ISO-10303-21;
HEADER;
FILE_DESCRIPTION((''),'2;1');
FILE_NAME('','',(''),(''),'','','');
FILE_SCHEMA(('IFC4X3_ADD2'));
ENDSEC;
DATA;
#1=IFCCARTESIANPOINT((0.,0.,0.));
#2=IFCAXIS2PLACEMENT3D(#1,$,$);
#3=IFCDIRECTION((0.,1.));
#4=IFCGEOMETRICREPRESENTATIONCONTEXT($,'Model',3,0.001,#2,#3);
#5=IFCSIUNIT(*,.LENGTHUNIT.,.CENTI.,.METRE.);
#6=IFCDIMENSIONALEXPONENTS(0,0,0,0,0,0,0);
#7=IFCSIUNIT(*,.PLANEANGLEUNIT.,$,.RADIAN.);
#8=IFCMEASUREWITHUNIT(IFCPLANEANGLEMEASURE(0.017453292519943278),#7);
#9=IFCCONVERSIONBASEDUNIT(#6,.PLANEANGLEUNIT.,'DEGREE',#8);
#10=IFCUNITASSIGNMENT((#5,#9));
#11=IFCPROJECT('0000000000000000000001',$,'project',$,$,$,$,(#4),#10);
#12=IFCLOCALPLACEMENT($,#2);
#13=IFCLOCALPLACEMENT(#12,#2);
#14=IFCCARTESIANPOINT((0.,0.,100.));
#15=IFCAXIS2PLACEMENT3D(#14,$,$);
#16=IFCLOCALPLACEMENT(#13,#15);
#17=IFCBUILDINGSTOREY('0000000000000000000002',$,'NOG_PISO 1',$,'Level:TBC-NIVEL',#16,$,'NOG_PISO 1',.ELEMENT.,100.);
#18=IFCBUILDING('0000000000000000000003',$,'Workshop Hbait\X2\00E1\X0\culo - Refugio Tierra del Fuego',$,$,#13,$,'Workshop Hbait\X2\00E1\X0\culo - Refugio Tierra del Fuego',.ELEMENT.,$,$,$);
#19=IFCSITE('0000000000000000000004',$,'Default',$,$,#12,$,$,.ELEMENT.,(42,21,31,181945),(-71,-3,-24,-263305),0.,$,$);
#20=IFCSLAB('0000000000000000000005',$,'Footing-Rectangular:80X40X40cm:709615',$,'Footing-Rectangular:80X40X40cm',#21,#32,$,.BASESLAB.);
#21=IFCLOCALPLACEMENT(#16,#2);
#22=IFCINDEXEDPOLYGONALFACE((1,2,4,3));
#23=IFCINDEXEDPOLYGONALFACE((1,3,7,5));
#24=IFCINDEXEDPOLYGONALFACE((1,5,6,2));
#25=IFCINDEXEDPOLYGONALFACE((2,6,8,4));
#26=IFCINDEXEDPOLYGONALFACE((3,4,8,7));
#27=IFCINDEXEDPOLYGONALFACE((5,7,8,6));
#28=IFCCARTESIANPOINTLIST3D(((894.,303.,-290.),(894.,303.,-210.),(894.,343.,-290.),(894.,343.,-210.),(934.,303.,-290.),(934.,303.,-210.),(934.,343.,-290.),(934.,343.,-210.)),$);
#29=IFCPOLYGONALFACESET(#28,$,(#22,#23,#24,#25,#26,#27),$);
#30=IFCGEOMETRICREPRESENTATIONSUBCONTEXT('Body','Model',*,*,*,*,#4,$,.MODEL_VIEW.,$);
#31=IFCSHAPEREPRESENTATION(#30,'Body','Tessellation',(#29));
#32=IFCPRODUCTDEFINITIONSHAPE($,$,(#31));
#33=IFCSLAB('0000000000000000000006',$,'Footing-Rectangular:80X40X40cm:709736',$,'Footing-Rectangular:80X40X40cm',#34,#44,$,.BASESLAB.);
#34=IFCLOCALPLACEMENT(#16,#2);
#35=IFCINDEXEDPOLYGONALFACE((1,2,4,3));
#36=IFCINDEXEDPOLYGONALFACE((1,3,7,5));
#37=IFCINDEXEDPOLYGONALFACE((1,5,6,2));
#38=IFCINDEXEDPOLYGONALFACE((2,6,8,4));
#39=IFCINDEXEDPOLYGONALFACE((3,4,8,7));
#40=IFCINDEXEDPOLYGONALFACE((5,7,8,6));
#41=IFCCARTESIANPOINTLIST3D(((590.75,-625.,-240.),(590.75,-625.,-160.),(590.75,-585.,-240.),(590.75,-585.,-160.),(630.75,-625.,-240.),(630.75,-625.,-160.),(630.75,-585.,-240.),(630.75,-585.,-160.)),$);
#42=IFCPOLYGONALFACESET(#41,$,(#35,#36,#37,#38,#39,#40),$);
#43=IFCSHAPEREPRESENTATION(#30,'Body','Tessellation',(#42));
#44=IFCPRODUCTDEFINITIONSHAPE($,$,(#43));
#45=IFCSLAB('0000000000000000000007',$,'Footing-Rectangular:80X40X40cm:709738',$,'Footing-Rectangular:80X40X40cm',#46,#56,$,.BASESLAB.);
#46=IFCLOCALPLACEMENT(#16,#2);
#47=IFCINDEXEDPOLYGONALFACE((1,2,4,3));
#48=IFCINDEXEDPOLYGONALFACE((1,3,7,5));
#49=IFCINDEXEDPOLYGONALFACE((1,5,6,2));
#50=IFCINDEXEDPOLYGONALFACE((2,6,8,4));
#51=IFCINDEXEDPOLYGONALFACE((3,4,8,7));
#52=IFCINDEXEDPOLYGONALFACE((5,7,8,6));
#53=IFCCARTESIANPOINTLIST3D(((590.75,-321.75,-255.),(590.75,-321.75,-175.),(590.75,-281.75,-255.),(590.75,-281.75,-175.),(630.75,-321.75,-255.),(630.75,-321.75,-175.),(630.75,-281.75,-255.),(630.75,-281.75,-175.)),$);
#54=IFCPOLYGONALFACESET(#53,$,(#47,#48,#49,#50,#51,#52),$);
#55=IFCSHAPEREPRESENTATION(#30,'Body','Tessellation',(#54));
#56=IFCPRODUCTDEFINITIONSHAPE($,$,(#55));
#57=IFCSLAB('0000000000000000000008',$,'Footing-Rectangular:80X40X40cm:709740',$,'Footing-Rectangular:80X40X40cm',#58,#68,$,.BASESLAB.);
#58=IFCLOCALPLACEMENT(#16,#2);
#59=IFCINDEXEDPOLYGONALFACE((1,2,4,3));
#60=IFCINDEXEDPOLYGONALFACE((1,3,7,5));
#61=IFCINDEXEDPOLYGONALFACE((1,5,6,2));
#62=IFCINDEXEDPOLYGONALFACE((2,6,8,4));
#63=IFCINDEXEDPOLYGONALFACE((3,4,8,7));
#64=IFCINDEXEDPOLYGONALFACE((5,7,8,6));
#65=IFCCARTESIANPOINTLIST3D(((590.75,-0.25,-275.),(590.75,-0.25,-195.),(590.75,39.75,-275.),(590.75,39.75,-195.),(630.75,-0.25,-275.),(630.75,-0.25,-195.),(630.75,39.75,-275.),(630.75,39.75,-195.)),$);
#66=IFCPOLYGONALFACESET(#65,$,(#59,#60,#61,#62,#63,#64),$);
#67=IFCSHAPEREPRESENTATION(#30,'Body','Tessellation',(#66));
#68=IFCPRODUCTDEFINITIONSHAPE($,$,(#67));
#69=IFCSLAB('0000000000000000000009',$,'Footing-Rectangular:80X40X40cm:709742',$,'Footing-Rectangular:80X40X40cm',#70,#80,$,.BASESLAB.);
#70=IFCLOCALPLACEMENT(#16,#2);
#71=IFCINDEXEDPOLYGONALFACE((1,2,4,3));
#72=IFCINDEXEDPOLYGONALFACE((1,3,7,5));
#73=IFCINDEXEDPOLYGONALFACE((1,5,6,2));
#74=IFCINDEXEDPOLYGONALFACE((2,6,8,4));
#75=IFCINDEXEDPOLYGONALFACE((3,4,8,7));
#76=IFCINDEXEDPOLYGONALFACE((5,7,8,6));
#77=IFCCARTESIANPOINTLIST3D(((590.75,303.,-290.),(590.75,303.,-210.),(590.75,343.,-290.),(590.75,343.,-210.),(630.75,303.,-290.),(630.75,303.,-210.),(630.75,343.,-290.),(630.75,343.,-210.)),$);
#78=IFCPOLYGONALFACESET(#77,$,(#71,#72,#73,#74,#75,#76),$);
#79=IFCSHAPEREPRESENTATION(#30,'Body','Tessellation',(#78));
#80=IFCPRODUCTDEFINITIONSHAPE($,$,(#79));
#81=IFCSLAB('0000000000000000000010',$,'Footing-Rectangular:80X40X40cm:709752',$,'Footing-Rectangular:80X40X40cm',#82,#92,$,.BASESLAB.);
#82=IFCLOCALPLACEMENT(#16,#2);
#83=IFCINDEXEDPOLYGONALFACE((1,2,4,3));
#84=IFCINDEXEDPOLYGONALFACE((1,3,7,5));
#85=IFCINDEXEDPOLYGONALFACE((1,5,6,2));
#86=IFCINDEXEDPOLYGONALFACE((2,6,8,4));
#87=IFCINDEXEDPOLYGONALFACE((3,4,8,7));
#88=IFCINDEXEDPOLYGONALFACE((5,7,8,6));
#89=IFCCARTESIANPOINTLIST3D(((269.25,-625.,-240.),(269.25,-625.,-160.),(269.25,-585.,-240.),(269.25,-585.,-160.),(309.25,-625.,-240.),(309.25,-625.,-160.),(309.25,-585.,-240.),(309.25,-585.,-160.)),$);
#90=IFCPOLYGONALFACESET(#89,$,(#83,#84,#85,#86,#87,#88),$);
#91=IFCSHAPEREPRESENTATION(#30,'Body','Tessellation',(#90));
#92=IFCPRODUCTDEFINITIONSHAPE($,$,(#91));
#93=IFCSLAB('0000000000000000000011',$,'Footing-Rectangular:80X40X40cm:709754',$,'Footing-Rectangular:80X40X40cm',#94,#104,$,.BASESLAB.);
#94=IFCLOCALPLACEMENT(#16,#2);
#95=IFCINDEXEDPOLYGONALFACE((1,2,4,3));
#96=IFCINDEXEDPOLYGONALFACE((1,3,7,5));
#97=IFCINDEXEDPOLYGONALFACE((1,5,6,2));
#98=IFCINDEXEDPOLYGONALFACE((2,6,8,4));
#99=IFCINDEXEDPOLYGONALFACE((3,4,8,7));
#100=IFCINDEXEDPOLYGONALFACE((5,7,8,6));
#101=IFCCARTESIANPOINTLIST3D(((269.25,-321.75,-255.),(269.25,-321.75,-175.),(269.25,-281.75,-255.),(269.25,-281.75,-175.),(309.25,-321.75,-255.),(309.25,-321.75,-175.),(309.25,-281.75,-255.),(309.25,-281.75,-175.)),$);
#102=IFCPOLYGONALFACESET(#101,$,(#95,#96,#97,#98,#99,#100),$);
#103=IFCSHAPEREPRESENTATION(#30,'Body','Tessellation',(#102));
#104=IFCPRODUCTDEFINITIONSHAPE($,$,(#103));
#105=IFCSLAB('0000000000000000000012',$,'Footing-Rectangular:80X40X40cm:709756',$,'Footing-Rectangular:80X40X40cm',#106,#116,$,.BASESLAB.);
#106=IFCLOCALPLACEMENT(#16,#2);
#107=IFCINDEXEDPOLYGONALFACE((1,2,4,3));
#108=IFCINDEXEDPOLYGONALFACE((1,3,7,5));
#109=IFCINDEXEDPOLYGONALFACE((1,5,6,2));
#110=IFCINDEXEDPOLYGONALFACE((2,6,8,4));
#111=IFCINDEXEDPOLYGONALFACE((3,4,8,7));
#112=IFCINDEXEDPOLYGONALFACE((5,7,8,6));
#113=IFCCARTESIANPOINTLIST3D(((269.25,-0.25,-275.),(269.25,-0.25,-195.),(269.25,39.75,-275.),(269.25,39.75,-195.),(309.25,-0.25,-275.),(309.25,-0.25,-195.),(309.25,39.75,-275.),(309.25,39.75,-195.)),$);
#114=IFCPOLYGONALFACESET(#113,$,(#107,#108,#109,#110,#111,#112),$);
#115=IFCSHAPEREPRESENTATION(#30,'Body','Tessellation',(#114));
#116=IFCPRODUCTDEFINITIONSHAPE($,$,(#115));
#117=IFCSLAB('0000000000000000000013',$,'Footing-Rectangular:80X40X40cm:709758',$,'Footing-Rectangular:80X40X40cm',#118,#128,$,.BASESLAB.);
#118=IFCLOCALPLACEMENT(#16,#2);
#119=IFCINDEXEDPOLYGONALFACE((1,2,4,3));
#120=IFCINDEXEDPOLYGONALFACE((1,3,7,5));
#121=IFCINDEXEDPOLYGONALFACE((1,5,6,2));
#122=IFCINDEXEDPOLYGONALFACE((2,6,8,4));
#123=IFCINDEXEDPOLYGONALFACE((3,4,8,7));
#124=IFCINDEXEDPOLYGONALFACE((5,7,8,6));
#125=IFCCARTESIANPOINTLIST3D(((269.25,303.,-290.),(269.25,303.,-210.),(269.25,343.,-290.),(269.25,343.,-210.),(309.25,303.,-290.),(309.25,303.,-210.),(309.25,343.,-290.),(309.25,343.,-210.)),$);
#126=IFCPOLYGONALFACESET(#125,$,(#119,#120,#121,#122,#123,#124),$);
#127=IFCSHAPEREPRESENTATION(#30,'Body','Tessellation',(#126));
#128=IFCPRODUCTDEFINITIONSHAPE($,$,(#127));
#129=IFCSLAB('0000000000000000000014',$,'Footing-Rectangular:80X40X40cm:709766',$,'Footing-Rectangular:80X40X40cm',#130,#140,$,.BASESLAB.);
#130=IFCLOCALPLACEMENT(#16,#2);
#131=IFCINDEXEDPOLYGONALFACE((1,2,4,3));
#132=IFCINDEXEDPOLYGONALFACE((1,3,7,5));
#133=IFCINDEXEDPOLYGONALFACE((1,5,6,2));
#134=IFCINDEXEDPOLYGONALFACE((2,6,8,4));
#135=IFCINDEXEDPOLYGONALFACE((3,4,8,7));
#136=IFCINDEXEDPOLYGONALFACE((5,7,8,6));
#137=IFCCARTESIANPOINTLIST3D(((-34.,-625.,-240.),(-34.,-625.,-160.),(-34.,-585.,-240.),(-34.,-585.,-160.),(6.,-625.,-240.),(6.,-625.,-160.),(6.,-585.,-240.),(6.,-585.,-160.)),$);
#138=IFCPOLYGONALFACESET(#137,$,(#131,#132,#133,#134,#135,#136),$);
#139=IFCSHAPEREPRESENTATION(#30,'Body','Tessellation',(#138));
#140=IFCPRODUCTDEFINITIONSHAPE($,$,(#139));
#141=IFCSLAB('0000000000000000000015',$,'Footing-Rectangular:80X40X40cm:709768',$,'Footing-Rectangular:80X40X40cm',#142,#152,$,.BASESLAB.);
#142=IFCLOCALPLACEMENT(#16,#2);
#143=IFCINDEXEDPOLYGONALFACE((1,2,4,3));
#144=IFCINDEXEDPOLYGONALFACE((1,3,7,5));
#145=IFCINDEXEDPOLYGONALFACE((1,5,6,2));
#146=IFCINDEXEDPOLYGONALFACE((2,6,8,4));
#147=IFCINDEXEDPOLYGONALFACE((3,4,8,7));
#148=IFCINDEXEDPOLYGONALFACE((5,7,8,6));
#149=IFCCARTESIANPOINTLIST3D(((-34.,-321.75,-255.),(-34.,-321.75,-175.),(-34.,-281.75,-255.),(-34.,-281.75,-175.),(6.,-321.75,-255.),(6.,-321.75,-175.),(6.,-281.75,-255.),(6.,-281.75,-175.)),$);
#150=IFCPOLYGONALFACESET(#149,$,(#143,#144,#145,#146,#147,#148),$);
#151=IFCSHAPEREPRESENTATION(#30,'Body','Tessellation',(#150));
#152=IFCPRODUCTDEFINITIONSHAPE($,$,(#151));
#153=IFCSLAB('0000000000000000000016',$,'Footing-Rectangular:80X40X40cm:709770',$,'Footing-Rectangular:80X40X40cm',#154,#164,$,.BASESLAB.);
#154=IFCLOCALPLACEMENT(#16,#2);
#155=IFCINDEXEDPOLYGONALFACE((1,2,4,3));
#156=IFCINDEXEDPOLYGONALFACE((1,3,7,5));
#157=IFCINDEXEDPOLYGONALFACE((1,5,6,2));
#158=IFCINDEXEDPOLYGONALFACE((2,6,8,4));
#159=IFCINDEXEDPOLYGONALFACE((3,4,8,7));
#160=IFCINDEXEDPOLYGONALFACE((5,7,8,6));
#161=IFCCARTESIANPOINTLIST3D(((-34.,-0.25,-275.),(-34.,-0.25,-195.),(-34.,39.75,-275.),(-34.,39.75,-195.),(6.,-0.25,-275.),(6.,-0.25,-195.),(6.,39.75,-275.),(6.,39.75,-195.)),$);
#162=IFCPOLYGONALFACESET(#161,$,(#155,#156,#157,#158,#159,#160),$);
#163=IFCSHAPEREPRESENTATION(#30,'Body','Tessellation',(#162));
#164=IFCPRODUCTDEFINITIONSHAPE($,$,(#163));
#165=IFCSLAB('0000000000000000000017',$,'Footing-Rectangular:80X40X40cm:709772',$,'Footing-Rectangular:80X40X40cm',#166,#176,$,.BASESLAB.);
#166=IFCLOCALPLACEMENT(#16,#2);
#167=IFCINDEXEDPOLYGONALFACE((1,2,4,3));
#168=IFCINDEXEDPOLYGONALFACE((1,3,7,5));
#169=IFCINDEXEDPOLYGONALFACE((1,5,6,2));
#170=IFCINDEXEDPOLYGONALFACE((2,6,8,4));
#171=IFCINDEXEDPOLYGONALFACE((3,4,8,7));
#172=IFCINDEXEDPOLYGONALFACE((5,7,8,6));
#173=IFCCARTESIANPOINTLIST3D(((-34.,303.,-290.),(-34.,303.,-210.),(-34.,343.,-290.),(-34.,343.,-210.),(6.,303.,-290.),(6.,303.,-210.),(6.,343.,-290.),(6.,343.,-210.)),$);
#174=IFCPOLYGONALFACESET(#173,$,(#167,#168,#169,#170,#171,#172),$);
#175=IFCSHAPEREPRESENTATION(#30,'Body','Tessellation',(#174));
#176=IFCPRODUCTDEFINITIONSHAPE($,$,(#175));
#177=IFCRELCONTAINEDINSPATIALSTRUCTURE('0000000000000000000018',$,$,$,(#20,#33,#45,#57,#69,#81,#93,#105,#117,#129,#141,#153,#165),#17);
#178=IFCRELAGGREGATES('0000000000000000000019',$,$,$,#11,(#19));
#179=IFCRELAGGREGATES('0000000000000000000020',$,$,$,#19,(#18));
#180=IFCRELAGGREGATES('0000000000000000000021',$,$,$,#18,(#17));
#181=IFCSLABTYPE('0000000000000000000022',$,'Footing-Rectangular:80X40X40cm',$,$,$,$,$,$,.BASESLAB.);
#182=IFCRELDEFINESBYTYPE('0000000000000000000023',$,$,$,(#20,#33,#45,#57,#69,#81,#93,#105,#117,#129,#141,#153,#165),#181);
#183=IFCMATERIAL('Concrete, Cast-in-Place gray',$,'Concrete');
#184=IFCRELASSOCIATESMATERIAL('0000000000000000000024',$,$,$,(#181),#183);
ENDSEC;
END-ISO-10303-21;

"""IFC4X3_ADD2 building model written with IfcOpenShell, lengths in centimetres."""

from ifc_helpers import new_model, entity, si_unit, converted_unit, direction, frame, frame_2d, origin, origin_2d_with_axis, place, context, subcontext, project, spatial, rectangle, extrude, material, type_object, element, save


model = new_model("IFC4X3_ADD2")

# Units and contexts
model_context = context("Model", 3, precision=0.001, world=origin(), true_north=direction((0.0, 1.0)))
body_context = subcontext(model_context, "Body", "Model", "MODEL_VIEW")
ifc_project = project(units=[si_unit("LENGTHUNIT", "METRE", prefix="CENTI"), converted_unit("PLANEANGLEUNIT", "DEGREE", entity("IfcPlaneAngleMeasure", 0.017453292519943278), si_unit("PLANEANGLEUNIT", "RADIAN"), dimensions=[0, 0, 0, 0, 0, 0, 0])], contexts=[model_context])

# Site, building, storey
site_placement = place(None, origin())
site = spatial("IfcSite", under=ifc_project, at=site_placement, Name="Default", CompositionType="ELEMENT", RefLatitude=(42, 21, 31, 181945), RefLongitude=(-71, -3, -24, -263305), RefElevation=0.0)
building_placement = place(site_placement, origin())
building = spatial("IfcBuilding", under=site, at=building_placement, Name="Workshop Hbaitáculo - Refugio Tierra del Fuego", LongName="Workshop Hbaitáculo - Refugio Tierra del Fuego", CompositionType="ELEMENT")
storey_placement = place(building_placement, frame((0.0, 0.0, 100.0)))
storey = spatial("IfcBuildingStorey", under=building, at=storey_placement, Name="NOG_PISO 1", ObjectType="Level:TBC-NIVEL", LongName="NOG_PISO 1", CompositionType="ELEMENT", Elevation=100.0)

# Slabs
ifc_material_1 = material(Name="Concrete, Cast-in-Place gray", Category="Concrete")
slab_type_1 = type_object("IfcSlabType", Name="Footing-Rectangular:80X40X40cm", PredefinedType="BASESLAB", material=ifc_material_1)
slab_1_placement = place(storey_placement, frame((0.0, 0.0, -210.0)))
element("IfcSlab", 1, at=slab_1_placement, inside=storey, type_object=slab_type_1, Name="Footing-Rectangular:80X40X40cm:709615", ObjectType="Footing-Rectangular:80X40X40cm", PredefinedType="BASESLAB", context=body_context, shape_type="SweptSolid", body=[
    extrude(rectangle(XDim=40.0, YDim=40.0, at=origin_2d_with_axis()), frame((914.0, 323.0, -80.0), z_axis=(0.0, 0.0, 1.0), x_axis=(-1.0, 0.0, 0.0)), (0.0, 0.0, 1.0), 80.0),
])
slab_2_placement = place(storey_placement, frame((0.0, 0.0, -160.0)))
element("IfcSlab", 2, at=slab_2_placement, inside=storey, type_object=slab_type_1, Name="Footing-Rectangular:80X40X40cm:709736", ObjectType="Footing-Rectangular:80X40X40cm", PredefinedType="BASESLAB", context=body_context, shape_type="SweptSolid", body=[
    extrude(rectangle(XDim=40.0, YDim=40.0, at=origin_2d_with_axis()), frame((610.75, -605.0, -80.0), z_axis=(0.0, 0.0, 1.0), x_axis=(-1.0, 0.0, 0.0)), (0.0, 0.0, 1.0), 80.0),
])
slab_3_placement = place(storey_placement, frame((0.0, 0.0, -175.0)))
element("IfcSlab", 3, at=slab_3_placement, inside=storey, type_object=slab_type_1, Name="Footing-Rectangular:80X40X40cm:709738", ObjectType="Footing-Rectangular:80X40X40cm", PredefinedType="BASESLAB", context=body_context, shape_type="SweptSolid", body=[
    extrude(rectangle(XDim=40.0, YDim=40.0, at=origin_2d_with_axis()), frame((610.75, -301.75, -80.0), z_axis=(0.0, 0.0, 1.0), x_axis=(-1.0, 0.0, 0.0)), (0.0, 0.0, 1.0), 80.0),
])
slab_4_placement = place(storey_placement, frame((0.0, 0.0, -195.0)))
element("IfcSlab", 4, at=slab_4_placement, inside=storey, type_object=slab_type_1, Name="Footing-Rectangular:80X40X40cm:709740", ObjectType="Footing-Rectangular:80X40X40cm", PredefinedType="BASESLAB", context=body_context, shape_type="SweptSolid", body=[
    extrude(rectangle(XDim=40.0, YDim=40.0, at=origin_2d_with_axis()), frame((610.75, 19.75, -80.0), z_axis=(0.0, 0.0, 1.0), x_axis=(-1.0, 0.0, 0.0)), (0.0, 0.0, 1.0), 80.0),
])
slab_5_placement = place(storey_placement, frame((0.0, 0.0, -210.0)))
element("IfcSlab", 5, at=slab_5_placement, inside=storey, type_object=slab_type_1, Name="Footing-Rectangular:80X40X40cm:709742", ObjectType="Footing-Rectangular:80X40X40cm", PredefinedType="BASESLAB", context=body_context, shape_type="SweptSolid", body=[
    extrude(rectangle(XDim=40.0, YDim=40.0, at=origin_2d_with_axis()), frame((610.75, 323.0, -80.0), z_axis=(0.0, 0.0, 1.0), x_axis=(-1.0, 0.0, 0.0)), (0.0, 0.0, 1.0), 80.0),
])
slab_6_placement = place(storey_placement, frame((0.0, 0.0, -160.0)))
element("IfcSlab", 6, at=slab_6_placement, inside=storey, type_object=slab_type_1, Name="Footing-Rectangular:80X40X40cm:709752", ObjectType="Footing-Rectangular:80X40X40cm", PredefinedType="BASESLAB", context=body_context, shape_type="SweptSolid", body=[
    extrude(rectangle(XDim=40.0, YDim=40.0, at=origin_2d_with_axis()), frame((289.25, -605.0, -80.0), z_axis=(0.0, 0.0, 1.0), x_axis=(-1.0, 0.0, 0.0)), (0.0, 0.0, 1.0), 80.0),
])
slab_7_placement = place(storey_placement, frame((0.0, 0.0, -175.0)))
element("IfcSlab", 7, at=slab_7_placement, inside=storey, type_object=slab_type_1, Name="Footing-Rectangular:80X40X40cm:709754", ObjectType="Footing-Rectangular:80X40X40cm", PredefinedType="BASESLAB", context=body_context, shape_type="SweptSolid", body=[
    extrude(rectangle(XDim=40.0, YDim=40.0, at=origin_2d_with_axis()), frame((289.25, -301.75, -80.0), z_axis=(0.0, 0.0, 1.0), x_axis=(-1.0, 0.0, 0.0)), (0.0, 0.0, 1.0), 80.0),
])
slab_8_placement = place(storey_placement, frame((0.0, 0.0, -195.0)))
element("IfcSlab", 8, at=slab_8_placement, inside=storey, type_object=slab_type_1, Name="Footing-Rectangular:80X40X40cm:709756", ObjectType="Footing-Rectangular:80X40X40cm", PredefinedType="BASESLAB", context=body_context, shape_type="SweptSolid", body=[
    extrude(rectangle(XDim=40.0, YDim=40.0, at=origin_2d_with_axis()), frame((289.25, 19.75, -80.0), z_axis=(0.0, 0.0, 1.0), x_axis=(-1.0, 0.0, 0.0)), (0.0, 0.0, 1.0), 80.0),
])
slab_9_placement = place(storey_placement, frame((0.0, 0.0, -210.0)))
element("IfcSlab", 9, at=slab_9_placement, inside=storey, type_object=slab_type_1, Name="Footing-Rectangular:80X40X40cm:709758", ObjectType="Footing-Rectangular:80X40X40cm", PredefinedType="BASESLAB", context=body_context, shape_type="SweptSolid", body=[
    extrude(rectangle(XDim=40.0, YDim=40.0, at=origin_2d_with_axis()), frame((289.25, 323.0, -80.0), z_axis=(0.0, 0.0, 1.0), x_axis=(-1.0, 0.0, 0.0)), (0.0, 0.0, 1.0), 80.0),
])
slab_10_placement = place(storey_placement, frame((0.0, 0.0, -160.0)))
element("IfcSlab", 10, at=slab_10_placement, inside=storey, type_object=slab_type_1, Name="Footing-Rectangular:80X40X40cm:709766", ObjectType="Footing-Rectangular:80X40X40cm", PredefinedType="BASESLAB", context=body_context, shape_type="SweptSolid", body=[
    extrude(rectangle(XDim=40.0, YDim=40.0, at=frame_2d((0.0, 0.0), x_axis=(1.0, 0.0))), frame((-14.0, -605.0, -80.0), z_axis=(0.0, 0.0, 1.0), x_axis=(-1.0, 0.0, 0.0)), (0.0, 0.0, 1.0), 80.0),
])
slab_11_placement = place(storey_placement, frame((0.0, 0.0, -175.0)))
element("IfcSlab", 11, at=slab_11_placement, inside=storey, type_object=slab_type_1, Name="Footing-Rectangular:80X40X40cm:709768", ObjectType="Footing-Rectangular:80X40X40cm", PredefinedType="BASESLAB", context=body_context, shape_type="SweptSolid", body=[
    extrude(rectangle(XDim=40.0, YDim=40.0, at=frame_2d((0.0, 0.0), x_axis=(1.0, 0.0))), frame((-14.0, -301.75, -80.0), z_axis=(0.0, 0.0, 1.0), x_axis=(-1.0, 0.0, 0.0)), (0.0, 0.0, 1.0), 80.0),
])
slab_12_placement = place(storey_placement, frame((0.0, 0.0, -195.0)))
element("IfcSlab", 12, at=slab_12_placement, inside=storey, type_object=slab_type_1, Name="Footing-Rectangular:80X40X40cm:709770", ObjectType="Footing-Rectangular:80X40X40cm", PredefinedType="BASESLAB", context=body_context, shape_type="SweptSolid", body=[
    extrude(rectangle(XDim=40.0, YDim=40.0, at=frame_2d((0.0, 0.0), x_axis=(1.0, 0.0))), frame((-14.0, 19.75, -80.0), z_axis=(0.0, 0.0, 1.0), x_axis=(-1.0, 0.0, 0.0)), (0.0, 0.0, 1.0), 80.0),
])
slab_13_placement = place(storey_placement, frame((0.0, 0.0, -210.0)))
element("IfcSlab", 13, at=slab_13_placement, inside=storey, type_object=slab_type_1, Name="Footing-Rectangular:80X40X40cm:709772", ObjectType="Footing-Rectangular:80X40X40cm", PredefinedType="BASESLAB", context=body_context, shape_type="SweptSolid", body=[
    extrude(rectangle(XDim=40.0, YDim=40.0, at=frame_2d((0.0, 0.0), x_axis=(1.0, 0.0))), frame((-14.0, 323.0, -80.0), z_axis=(0.0, 0.0, 1.0), x_axis=(-1.0, 0.0, 0.0)), (0.0, 0.0, 1.0), 80.0),
])

save(model, "model.ifc")
